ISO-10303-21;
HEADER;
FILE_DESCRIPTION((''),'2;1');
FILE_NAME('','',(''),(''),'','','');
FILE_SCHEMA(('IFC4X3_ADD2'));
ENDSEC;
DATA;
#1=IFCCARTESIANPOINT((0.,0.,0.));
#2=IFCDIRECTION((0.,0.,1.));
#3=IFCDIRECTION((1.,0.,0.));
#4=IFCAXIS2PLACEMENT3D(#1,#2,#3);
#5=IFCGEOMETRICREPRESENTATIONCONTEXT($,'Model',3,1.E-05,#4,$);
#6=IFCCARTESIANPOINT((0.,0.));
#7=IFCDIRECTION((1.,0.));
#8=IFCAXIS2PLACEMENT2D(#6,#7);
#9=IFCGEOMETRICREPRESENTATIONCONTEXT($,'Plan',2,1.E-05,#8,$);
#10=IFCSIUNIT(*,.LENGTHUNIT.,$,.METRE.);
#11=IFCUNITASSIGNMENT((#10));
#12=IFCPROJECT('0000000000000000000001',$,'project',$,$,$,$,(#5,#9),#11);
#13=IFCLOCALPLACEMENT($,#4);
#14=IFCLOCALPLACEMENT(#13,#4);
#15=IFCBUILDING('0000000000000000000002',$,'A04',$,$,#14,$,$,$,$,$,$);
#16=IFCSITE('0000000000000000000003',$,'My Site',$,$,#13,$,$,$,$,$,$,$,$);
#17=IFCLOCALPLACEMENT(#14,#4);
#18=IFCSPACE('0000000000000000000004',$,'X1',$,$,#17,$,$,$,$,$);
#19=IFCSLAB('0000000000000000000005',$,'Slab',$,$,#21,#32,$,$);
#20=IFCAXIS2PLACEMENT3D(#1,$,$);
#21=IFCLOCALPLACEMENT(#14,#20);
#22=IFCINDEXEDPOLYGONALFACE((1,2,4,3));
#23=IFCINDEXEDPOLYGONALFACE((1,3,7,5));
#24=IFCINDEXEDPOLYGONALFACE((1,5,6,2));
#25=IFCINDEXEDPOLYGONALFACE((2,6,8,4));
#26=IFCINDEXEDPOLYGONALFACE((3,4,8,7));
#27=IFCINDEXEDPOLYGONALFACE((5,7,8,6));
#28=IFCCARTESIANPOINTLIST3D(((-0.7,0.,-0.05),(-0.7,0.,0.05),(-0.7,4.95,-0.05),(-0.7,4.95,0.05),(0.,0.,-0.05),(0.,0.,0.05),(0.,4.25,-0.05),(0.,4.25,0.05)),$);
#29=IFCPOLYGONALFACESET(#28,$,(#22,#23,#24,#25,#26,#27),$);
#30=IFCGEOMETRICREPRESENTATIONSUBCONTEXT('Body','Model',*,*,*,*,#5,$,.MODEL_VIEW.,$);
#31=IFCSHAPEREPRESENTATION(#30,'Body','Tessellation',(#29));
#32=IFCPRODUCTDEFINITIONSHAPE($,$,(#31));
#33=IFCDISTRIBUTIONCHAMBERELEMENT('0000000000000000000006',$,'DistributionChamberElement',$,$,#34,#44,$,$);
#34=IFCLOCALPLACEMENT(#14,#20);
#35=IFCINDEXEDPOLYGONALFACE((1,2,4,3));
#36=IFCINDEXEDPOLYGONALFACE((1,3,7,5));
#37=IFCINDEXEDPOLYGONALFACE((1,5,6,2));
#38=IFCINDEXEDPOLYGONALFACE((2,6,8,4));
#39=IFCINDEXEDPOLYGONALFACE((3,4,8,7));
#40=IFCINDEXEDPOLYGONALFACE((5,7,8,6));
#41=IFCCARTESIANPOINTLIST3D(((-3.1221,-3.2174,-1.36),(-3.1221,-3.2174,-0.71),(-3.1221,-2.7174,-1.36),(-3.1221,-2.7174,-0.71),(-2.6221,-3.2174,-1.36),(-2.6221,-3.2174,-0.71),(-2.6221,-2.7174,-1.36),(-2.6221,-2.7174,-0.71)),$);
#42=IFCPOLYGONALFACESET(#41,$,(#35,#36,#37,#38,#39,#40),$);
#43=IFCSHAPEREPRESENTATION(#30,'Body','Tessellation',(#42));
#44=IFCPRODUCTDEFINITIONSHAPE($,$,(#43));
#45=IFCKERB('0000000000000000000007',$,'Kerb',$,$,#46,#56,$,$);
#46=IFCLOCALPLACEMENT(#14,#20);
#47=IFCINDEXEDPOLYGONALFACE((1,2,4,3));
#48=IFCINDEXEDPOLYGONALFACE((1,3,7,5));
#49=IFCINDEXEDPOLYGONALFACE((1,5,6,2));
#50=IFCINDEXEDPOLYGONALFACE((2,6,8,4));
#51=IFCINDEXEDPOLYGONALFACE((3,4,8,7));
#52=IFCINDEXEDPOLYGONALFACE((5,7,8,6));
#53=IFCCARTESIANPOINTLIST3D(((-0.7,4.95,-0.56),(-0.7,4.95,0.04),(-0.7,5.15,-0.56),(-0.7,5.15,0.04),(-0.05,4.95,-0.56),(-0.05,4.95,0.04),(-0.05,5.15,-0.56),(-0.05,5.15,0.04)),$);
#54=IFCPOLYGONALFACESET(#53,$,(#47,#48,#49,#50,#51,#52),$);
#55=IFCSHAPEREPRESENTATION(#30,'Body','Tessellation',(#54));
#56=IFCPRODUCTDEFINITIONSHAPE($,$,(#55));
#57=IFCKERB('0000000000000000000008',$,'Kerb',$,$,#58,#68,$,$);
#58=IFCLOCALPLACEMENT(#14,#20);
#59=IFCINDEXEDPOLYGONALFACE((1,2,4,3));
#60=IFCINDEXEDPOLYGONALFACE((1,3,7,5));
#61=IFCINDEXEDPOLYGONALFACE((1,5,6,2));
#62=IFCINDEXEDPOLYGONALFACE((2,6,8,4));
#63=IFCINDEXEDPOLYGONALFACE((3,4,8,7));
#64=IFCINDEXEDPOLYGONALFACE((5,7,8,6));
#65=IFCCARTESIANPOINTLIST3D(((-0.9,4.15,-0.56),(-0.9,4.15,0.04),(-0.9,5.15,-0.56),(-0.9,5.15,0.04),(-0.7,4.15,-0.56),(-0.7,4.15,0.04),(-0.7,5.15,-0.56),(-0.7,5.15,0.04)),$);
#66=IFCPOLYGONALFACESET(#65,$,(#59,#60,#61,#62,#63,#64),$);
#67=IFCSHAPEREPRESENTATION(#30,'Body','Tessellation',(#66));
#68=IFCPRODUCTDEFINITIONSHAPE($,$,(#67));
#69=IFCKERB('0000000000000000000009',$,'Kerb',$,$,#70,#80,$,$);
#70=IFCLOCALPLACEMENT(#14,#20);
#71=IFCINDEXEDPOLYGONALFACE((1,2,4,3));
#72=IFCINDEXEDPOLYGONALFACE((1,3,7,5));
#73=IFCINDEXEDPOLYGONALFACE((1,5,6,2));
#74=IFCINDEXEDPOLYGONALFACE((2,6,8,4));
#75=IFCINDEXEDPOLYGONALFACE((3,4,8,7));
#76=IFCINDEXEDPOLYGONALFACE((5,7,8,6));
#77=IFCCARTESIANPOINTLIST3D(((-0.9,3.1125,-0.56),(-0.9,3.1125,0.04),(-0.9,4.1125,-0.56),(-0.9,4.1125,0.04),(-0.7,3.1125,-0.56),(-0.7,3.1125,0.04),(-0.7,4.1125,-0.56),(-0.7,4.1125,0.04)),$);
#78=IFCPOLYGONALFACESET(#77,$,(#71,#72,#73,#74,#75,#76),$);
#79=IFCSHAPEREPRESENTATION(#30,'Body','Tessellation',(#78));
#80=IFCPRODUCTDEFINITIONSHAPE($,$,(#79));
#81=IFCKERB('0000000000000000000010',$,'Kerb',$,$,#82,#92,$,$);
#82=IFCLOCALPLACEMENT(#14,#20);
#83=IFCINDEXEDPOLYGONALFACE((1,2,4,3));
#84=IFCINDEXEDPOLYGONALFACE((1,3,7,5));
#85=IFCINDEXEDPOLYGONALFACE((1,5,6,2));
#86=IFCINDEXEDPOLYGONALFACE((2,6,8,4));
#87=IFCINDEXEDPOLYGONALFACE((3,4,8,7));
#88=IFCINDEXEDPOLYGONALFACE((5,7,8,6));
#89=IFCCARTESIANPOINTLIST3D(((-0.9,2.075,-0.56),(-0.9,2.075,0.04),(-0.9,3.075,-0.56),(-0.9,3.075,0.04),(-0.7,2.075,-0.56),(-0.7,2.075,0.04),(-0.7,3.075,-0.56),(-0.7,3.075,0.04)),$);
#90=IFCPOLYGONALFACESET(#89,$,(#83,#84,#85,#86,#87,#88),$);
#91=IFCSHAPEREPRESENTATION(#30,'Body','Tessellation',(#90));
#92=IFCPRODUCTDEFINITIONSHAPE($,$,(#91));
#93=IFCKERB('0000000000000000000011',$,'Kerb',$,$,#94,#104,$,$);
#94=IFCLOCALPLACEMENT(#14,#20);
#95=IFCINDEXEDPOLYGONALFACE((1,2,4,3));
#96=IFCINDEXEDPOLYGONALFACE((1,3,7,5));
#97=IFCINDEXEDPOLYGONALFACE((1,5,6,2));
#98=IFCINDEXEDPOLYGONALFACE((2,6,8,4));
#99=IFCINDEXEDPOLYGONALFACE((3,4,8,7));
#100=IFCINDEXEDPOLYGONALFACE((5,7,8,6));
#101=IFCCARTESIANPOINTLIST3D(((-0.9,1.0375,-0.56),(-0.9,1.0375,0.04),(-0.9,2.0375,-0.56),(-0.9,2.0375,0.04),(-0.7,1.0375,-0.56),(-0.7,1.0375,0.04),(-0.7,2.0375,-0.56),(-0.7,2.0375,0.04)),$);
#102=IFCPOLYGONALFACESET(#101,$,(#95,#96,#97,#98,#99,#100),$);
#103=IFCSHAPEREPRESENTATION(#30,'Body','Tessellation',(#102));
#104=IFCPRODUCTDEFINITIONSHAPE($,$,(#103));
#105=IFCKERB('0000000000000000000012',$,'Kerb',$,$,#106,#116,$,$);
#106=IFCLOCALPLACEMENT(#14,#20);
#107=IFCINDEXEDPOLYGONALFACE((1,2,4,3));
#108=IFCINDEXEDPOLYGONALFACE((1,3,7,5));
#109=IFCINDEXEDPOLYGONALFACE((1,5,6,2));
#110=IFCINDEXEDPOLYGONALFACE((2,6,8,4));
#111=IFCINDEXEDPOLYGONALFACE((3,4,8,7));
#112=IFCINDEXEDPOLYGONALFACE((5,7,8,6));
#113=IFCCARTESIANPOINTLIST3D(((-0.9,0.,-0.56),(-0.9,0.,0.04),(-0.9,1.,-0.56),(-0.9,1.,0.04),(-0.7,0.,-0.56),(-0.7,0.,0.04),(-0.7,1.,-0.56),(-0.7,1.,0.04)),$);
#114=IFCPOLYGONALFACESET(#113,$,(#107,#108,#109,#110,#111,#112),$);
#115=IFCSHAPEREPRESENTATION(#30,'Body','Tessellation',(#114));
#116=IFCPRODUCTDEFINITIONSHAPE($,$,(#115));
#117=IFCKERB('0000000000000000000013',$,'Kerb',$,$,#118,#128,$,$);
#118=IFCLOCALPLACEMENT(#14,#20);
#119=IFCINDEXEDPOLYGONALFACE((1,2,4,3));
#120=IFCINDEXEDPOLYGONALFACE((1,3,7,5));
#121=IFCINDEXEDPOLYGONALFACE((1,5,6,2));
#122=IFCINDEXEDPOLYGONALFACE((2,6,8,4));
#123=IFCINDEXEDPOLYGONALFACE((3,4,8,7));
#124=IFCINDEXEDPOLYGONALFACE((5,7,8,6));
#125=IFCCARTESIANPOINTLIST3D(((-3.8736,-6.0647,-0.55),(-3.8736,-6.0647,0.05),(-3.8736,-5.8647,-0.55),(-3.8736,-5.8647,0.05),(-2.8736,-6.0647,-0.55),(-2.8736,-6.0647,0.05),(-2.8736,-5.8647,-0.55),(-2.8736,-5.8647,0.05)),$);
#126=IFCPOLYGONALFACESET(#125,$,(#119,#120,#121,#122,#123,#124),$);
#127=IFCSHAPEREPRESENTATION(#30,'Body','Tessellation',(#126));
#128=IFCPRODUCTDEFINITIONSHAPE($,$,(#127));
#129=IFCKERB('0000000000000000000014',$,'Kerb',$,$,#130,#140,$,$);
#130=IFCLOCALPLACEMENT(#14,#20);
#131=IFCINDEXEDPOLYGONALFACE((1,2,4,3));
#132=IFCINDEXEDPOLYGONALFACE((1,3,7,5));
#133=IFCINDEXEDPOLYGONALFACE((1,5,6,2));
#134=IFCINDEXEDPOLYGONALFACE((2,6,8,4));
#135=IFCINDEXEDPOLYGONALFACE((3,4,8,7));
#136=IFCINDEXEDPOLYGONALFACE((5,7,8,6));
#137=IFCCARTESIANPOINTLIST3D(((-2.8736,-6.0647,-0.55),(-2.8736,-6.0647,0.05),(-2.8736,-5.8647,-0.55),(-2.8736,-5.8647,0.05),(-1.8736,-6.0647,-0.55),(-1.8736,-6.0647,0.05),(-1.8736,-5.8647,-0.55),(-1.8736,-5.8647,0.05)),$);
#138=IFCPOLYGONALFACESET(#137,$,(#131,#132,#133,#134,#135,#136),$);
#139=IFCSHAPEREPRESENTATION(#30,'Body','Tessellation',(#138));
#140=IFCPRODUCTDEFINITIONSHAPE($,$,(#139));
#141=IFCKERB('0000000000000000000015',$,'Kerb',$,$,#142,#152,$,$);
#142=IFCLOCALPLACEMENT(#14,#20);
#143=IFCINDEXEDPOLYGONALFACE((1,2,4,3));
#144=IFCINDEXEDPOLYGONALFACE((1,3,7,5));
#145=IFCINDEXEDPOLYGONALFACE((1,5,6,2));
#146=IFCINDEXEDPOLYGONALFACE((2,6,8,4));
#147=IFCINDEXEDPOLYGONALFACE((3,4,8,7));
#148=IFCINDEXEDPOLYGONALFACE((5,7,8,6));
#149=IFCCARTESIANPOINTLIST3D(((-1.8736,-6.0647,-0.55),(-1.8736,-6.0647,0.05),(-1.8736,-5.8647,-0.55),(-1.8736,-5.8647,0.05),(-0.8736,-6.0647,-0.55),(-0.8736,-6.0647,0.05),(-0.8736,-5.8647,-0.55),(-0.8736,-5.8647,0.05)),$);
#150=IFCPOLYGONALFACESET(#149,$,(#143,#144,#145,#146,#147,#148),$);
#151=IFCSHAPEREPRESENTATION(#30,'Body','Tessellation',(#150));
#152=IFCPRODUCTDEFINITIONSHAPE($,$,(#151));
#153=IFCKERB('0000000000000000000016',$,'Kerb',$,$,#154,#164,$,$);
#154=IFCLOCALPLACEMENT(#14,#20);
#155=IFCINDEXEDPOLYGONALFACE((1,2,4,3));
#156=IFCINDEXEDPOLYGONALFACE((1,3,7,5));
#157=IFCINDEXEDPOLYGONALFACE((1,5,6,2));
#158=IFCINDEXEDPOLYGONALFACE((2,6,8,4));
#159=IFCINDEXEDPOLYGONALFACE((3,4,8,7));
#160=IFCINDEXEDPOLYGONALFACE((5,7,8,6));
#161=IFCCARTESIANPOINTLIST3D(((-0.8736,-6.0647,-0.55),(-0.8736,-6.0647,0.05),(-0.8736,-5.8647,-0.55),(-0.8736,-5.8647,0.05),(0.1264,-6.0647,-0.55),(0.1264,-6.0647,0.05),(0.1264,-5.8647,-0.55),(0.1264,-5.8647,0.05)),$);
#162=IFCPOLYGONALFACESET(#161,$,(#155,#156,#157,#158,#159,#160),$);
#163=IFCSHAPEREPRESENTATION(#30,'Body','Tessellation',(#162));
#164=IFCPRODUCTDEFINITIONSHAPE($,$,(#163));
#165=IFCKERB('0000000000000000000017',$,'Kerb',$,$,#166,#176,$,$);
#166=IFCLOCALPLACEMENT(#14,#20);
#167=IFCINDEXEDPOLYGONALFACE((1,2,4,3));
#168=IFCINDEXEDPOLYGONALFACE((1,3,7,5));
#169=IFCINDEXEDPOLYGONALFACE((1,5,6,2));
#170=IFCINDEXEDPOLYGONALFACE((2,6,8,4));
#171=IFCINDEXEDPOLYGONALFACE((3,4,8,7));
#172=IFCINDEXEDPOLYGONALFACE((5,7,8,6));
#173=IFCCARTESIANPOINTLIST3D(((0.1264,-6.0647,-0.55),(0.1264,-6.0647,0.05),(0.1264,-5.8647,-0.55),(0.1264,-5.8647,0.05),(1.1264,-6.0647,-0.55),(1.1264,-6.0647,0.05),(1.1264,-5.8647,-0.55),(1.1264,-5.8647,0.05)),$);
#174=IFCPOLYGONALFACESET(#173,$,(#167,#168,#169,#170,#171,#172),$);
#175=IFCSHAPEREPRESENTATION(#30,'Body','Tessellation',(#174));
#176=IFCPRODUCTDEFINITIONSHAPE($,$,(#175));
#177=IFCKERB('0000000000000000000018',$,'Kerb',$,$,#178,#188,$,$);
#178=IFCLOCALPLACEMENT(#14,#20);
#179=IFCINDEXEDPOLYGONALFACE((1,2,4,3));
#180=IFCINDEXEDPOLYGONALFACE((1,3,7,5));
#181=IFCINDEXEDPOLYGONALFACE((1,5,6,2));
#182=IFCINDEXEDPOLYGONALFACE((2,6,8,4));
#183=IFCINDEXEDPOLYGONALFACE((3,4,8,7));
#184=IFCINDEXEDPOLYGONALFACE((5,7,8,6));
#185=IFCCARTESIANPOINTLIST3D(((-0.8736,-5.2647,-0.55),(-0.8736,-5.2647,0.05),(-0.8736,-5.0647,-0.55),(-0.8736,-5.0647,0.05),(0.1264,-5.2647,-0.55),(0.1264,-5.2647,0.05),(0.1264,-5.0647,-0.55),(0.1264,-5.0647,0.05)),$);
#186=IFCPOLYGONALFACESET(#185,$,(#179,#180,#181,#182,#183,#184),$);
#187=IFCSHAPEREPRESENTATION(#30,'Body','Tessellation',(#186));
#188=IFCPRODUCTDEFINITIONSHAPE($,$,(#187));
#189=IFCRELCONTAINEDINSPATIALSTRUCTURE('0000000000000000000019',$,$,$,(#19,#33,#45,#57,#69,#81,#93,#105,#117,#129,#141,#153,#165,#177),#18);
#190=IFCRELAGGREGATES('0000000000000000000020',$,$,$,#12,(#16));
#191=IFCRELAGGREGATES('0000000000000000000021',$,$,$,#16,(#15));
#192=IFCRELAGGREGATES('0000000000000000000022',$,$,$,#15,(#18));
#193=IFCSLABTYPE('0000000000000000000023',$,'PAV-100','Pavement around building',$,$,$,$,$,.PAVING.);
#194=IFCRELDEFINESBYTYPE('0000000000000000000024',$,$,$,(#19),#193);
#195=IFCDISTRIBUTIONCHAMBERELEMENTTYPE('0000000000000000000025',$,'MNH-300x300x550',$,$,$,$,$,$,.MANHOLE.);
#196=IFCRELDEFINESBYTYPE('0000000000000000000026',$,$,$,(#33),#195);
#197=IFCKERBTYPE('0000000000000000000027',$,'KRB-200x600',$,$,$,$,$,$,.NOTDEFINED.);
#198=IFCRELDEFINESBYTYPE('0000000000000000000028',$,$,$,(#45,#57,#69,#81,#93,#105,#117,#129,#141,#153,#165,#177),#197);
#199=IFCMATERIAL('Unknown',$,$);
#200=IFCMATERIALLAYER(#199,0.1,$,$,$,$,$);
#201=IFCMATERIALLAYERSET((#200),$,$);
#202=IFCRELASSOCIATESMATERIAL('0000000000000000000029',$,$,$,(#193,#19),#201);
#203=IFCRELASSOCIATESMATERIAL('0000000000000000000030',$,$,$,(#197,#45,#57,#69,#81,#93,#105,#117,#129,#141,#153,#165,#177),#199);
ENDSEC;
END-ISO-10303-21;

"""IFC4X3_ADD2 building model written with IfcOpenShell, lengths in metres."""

from ifc_helpers import new_model, si_unit, frame, origin_with_axes, origin_2d_with_axis, place, context, subcontext, project, spatial, indexed_curve, rectangle, outline, extrude, source, transform, mapped, material, layer, layer_set, layer_usage, material_profile, profile_set, profile_usage, type_object, type_shapes, element, save


model = new_model("IFC4X3_ADD2")

# Units and contexts
model_context = context("Model", 3, precision=1e-05, world=origin_with_axes())
plan_context = context("Plan", 2, precision=1e-05, world=origin_2d_with_axis())
body_context = subcontext(model_context, "Body", "Model", "MODEL_VIEW")
ifc_project = project(units=[si_unit("LENGTHUNIT", "METRE")], contexts=[model_context, plan_context])

# Site, building, space
site_placement = place(None, origin_with_axes())
site = spatial("IfcSite", under=ifc_project, at=site_placement, Name="My Site")
building_placement = place(site_placement, origin_with_axes())
building = spatial("IfcBuilding", under=site, at=building_placement, Name="A04")
space_placement = place(building_placement, origin_with_axes())
space = spatial("IfcSpace", under=building, at=space_placement, Name="X1")

# Slab
ifc_material = material(Name="Unknown")
ifc_layer_1 = layer(ifc_material, 0.1)
ifc_layer_set_1 = layer_set([ifc_layer_1])
ifc_layer_usage_1 = layer_usage(ifc_layer_set_1, "AXIS3", "POSITIVE", -0.1)
slab_type_1 = type_object("IfcSlabType", Name="PAV-100", Description="Pavement around building", PredefinedType="PAVING", material=ifc_layer_set_1)
slab_1_placement = place(space_placement, frame((-0.7, 4.95, 0.05), z_axis=(0.0, 0.0, 1.0), x_axis=(0.0, 1.0, 0.0)))
element("IfcSlab", 1, at=slab_1_placement, inside=space, type_object=slab_type_1, material=ifc_layer_usage_1, Name="Slab", context=body_context, shape_type="SweptSolid", body=[
    extrude(outline(indexed_curve([(0.0, 0.0), (-0.7, -0.7), (-4.95, -0.7), (-4.95, 0.0), (0.0, 0.0)])), frame((0.0, 0.0, -0.1), z_axis=(0.0, 0.0, 1.0), x_axis=(1.0, 0.0, 0.0)), (0.0, 0.0, 1.0), 0.1),
])

# Distribution chamber element
distribution_chamber_element_type = type_object("IfcDistributionChamberElementType", Name="MNH-300x300x550", PredefinedType="MANHOLE")
shared_shape = source(origin_with_axes(), body_context, "Body", "SweptSolid", [
    extrude(outline(indexed_curve([(0.0, 0.0), (0.5, 0.0), (0.5, 0.5), (0.0, 0.5), (0.0, 0.0)])), origin_with_axes(), (0.0, 0.0, 1.0), 0.65),
])
type_shapes(distribution_chamber_element_type, [shared_shape])
distribution_chamber_element_placement = place(space_placement, frame((-3.1221, -3.2174, -1.36), z_axis=(0.0, 0.0, 1.0), x_axis=(1.0, 0.0, 0.0)))
element("IfcDistributionChamberElement", 2, at=distribution_chamber_element_placement, inside=space, type_object=distribution_chamber_element_type, Name="DistributionChamberElement", context=body_context, shape_type="MappedRepresentation", body=[
    mapped(shared_shape, transform((0.0, 0.0, 0.0), x_axis=(1.0, 0.0, 0.0), y_axis=(0.0, 1.0, 0.0), z_axis=(0.0, 0.0, 1.0), scale=1.0)),
])

# Kerbs
ifc_material_profile = material_profile(ifc_material, rectangle(XDim=0.2, YDim=0.6))
ifc_profile_set = profile_set([ifc_material_profile])
ifc_profile_usage_1 = profile_usage(ifc_profile_set, cardinal=2)
kerb_type = type_object("IfcKerbType", Name="KRB-200x600", PredefinedType="NOTDEFINED", material=ifc_profile_set)
kerb_1_placement = place(space_placement, frame((-0.05, 5.05, -0.56), z_axis=(-1.0, 0.0, 0.0), x_axis=(0.0, -1.0, 0.0)))
element("IfcKerb", 3, at=kerb_1_placement, inside=space, type_object=kerb_type, material=ifc_profile_usage_1, Name="Kerb", context=body_context, shape_type="SweptSolid", body=[
    extrude(rectangle(XDim=0.2, YDim=0.6), frame((0.0, 0.3, 0.0), z_axis=(0.0, 0.0, 1.0), x_axis=(1.0, 0.0, 0.0)), (0.0, 0.0, 1.0), 0.65),
])
ifc_profile_usage_2 = profile_usage(ifc_profile_set, cardinal=2)
kerb_2_placement = place(space_placement, frame((-0.8, 5.15, -0.56), z_axis=(0.0, -1.0, 0.0), x_axis=(1.0, 0.0, 0.0)))
element("IfcKerb", 4, at=kerb_2_placement, inside=space, type_object=kerb_type, material=ifc_profile_usage_2, Name="Kerb", context=body_context, shape_type="SweptSolid", body=[
    extrude(rectangle(XDim=0.2, YDim=0.6), frame((0.0, 0.3, 0.0), z_axis=(0.0, 0.0, 1.0), x_axis=(1.0, 0.0, 0.0)), (0.0, 0.0, 1.0), 1.0),
])
ifc_profile_usage_3 = profile_usage(ifc_profile_set, cardinal=2)
kerb_3_placement = place(space_placement, frame((-0.8, 4.1125, -0.56), z_axis=(0.0, -1.0, 0.0), x_axis=(1.0, 0.0, 0.0)))
element("IfcKerb", 5, at=kerb_3_placement, inside=space, type_object=kerb_type, material=ifc_profile_usage_3, Name="Kerb", context=body_context, shape_type="SweptSolid", body=[
    extrude(rectangle(XDim=0.2, YDim=0.6), frame((0.0, 0.3, 0.0), z_axis=(0.0, 0.0, 1.0), x_axis=(1.0, 0.0, 0.0)), (0.0, 0.0, 1.0), 1.0),
])
ifc_profile_usage_4 = profile_usage(ifc_profile_set, cardinal=2)
kerb_4_placement = place(space_placement, frame((-0.8, 3.075, -0.56), z_axis=(0.0, -1.0, 0.0), x_axis=(1.0, 0.0, 0.0)))
element("IfcKerb", 6, at=kerb_4_placement, inside=space, type_object=kerb_type, material=ifc_profile_usage_4, Name="Kerb", context=body_context, shape_type="SweptSolid", body=[
    extrude(rectangle(XDim=0.2, YDim=0.6), frame((0.0, 0.3, 0.0), z_axis=(0.0, 0.0, 1.0), x_axis=(1.0, 0.0, 0.0)), (0.0, 0.0, 1.0), 1.0),
])
ifc_profile_usage_5 = profile_usage(ifc_profile_set, cardinal=2)
kerb_5_placement = place(space_placement, frame((-0.8, 2.0375, -0.56), z_axis=(0.0, -1.0, 0.0), x_axis=(1.0, 0.0, 0.0)))
element("IfcKerb", 7, at=kerb_5_placement, inside=space, type_object=kerb_type, material=ifc_profile_usage_5, Name="Kerb", context=body_context, shape_type="SweptSolid", body=[
    extrude(rectangle(XDim=0.2, YDim=0.6), frame((0.0, 0.3, 0.0), z_axis=(0.0, 0.0, 1.0), x_axis=(1.0, 0.0, 0.0)), (0.0, 0.0, 1.0), 1.0),
])
ifc_profile_usage_6 = profile_usage(ifc_profile_set, cardinal=2)
kerb_6_placement = place(space_placement, frame((-0.8, 1.0, -0.56), z_axis=(0.0, -1.0, 0.0), x_axis=(1.0, 0.0, 0.0)))
element("IfcKerb", 8, at=kerb_6_placement, inside=space, type_object=kerb_type, material=ifc_profile_usage_6, Name="Kerb", context=body_context, shape_type="SweptSolid", body=[
    extrude(rectangle(XDim=0.2, YDim=0.6), frame((0.0, 0.3, 0.0), z_axis=(0.0, 0.0, 1.0), x_axis=(1.0, 0.0, 0.0)), (0.0, 0.0, 1.0), 1.0),
])
ifc_profile_usage_7 = profile_usage(ifc_profile_set, cardinal=2)
kerb_7_placement = place(space_placement, frame((-3.8736, -5.9647, -0.55), z_axis=(1.0, 0.0, 0.0), x_axis=(0.0, 1.0, 0.0)))
element("IfcKerb", 9, at=kerb_7_placement, inside=space, type_object=kerb_type, material=ifc_profile_usage_7, Name="Kerb", context=body_context, shape_type="SweptSolid", body=[
    extrude(rectangle(XDim=0.2, YDim=0.6), frame((0.0, 0.3, 0.0), z_axis=(0.0, 0.0, 1.0), x_axis=(1.0, 0.0, 0.0)), (0.0, 0.0, 1.0), 1.0),
])
ifc_profile_usage_8 = profile_usage(ifc_profile_set, cardinal=2)
kerb_8_placement = place(space_placement, frame((-2.8736, -5.9647, -0.55), z_axis=(1.0, 0.0, 0.0), x_axis=(0.0, 1.0, 0.0)))
element("IfcKerb", 10, at=kerb_8_placement, inside=space, type_object=kerb_type, material=ifc_profile_usage_8, Name="Kerb", context=body_context, shape_type="SweptSolid", body=[
    extrude(rectangle(XDim=0.2, YDim=0.6), frame((0.0, 0.3, 0.0), z_axis=(0.0, 0.0, 1.0), x_axis=(1.0, 0.0, 0.0)), (0.0, 0.0, 1.0), 1.0),
])
ifc_profile_usage_9 = profile_usage(ifc_profile_set, cardinal=2)
kerb_9_placement = place(space_placement, frame((-1.8736, -5.9647, -0.55), z_axis=(1.0, 0.0, 0.0), x_axis=(0.0, 1.0, 0.0)))
element("IfcKerb", 11, at=kerb_9_placement, inside=space, type_object=kerb_type, material=ifc_profile_usage_9, Name="Kerb", context=body_context, shape_type="SweptSolid", body=[
    extrude(rectangle(XDim=0.2, YDim=0.6), frame((0.0, 0.3, 0.0), z_axis=(0.0, 0.0, 1.0), x_axis=(1.0, 0.0, 0.0)), (0.0, 0.0, 1.0), 1.0),
])
ifc_profile_usage_10 = profile_usage(ifc_profile_set, cardinal=2)
kerb_10_placement = place(space_placement, frame((-0.8736, -5.9647, -0.55), z_axis=(1.0, 0.0, 0.0), x_axis=(0.0, 1.0, 0.0)))
element("IfcKerb", 12, at=kerb_10_placement, inside=space, type_object=kerb_type, material=ifc_profile_usage_10, Name="Kerb", context=body_context, shape_type="SweptSolid", body=[
    extrude(rectangle(XDim=0.2, YDim=0.6), frame((0.0, 0.3, 0.0), z_axis=(0.0, 0.0, 1.0), x_axis=(1.0, 0.0, 0.0)), (0.0, 0.0, 1.0), 1.0),
])
ifc_profile_usage_11 = profile_usage(ifc_profile_set, cardinal=2)
kerb_11_placement = place(space_placement, frame((0.1264, -5.9647, -0.55), z_axis=(1.0, 0.0, 0.0), x_axis=(0.0, 1.0, 0.0)))
element("IfcKerb", 13, at=kerb_11_placement, inside=space, type_object=kerb_type, material=ifc_profile_usage_11, Name="Kerb", context=body_context, shape_type="SweptSolid", body=[
    extrude(rectangle(XDim=0.2, YDim=0.6), frame((0.0, 0.3, 0.0), z_axis=(0.0, 0.0, 1.0), x_axis=(1.0, 0.0, 0.0)), (0.0, 0.0, 1.0), 1.0),
])
ifc_profile_usage_12 = profile_usage(ifc_profile_set, cardinal=2)
kerb_12_placement = place(space_placement, frame((-0.8736, -5.1647, -0.55), z_axis=(1.0, 0.0, 0.0), x_axis=(0.0, 1.0, 0.0)))
element("IfcKerb", 14, at=kerb_12_placement, inside=space, type_object=kerb_type, material=ifc_profile_usage_12, Name="Kerb", context=body_context, shape_type="SweptSolid", body=[
    extrude(rectangle(XDim=0.2, YDim=0.6), frame((0.0, 0.3, 0.0), z_axis=(0.0, 0.0, 1.0), x_axis=(1.0, 0.0, 0.0)), (0.0, 0.0, 1.0), 1.0),
])

save(model, "model.ifc")
